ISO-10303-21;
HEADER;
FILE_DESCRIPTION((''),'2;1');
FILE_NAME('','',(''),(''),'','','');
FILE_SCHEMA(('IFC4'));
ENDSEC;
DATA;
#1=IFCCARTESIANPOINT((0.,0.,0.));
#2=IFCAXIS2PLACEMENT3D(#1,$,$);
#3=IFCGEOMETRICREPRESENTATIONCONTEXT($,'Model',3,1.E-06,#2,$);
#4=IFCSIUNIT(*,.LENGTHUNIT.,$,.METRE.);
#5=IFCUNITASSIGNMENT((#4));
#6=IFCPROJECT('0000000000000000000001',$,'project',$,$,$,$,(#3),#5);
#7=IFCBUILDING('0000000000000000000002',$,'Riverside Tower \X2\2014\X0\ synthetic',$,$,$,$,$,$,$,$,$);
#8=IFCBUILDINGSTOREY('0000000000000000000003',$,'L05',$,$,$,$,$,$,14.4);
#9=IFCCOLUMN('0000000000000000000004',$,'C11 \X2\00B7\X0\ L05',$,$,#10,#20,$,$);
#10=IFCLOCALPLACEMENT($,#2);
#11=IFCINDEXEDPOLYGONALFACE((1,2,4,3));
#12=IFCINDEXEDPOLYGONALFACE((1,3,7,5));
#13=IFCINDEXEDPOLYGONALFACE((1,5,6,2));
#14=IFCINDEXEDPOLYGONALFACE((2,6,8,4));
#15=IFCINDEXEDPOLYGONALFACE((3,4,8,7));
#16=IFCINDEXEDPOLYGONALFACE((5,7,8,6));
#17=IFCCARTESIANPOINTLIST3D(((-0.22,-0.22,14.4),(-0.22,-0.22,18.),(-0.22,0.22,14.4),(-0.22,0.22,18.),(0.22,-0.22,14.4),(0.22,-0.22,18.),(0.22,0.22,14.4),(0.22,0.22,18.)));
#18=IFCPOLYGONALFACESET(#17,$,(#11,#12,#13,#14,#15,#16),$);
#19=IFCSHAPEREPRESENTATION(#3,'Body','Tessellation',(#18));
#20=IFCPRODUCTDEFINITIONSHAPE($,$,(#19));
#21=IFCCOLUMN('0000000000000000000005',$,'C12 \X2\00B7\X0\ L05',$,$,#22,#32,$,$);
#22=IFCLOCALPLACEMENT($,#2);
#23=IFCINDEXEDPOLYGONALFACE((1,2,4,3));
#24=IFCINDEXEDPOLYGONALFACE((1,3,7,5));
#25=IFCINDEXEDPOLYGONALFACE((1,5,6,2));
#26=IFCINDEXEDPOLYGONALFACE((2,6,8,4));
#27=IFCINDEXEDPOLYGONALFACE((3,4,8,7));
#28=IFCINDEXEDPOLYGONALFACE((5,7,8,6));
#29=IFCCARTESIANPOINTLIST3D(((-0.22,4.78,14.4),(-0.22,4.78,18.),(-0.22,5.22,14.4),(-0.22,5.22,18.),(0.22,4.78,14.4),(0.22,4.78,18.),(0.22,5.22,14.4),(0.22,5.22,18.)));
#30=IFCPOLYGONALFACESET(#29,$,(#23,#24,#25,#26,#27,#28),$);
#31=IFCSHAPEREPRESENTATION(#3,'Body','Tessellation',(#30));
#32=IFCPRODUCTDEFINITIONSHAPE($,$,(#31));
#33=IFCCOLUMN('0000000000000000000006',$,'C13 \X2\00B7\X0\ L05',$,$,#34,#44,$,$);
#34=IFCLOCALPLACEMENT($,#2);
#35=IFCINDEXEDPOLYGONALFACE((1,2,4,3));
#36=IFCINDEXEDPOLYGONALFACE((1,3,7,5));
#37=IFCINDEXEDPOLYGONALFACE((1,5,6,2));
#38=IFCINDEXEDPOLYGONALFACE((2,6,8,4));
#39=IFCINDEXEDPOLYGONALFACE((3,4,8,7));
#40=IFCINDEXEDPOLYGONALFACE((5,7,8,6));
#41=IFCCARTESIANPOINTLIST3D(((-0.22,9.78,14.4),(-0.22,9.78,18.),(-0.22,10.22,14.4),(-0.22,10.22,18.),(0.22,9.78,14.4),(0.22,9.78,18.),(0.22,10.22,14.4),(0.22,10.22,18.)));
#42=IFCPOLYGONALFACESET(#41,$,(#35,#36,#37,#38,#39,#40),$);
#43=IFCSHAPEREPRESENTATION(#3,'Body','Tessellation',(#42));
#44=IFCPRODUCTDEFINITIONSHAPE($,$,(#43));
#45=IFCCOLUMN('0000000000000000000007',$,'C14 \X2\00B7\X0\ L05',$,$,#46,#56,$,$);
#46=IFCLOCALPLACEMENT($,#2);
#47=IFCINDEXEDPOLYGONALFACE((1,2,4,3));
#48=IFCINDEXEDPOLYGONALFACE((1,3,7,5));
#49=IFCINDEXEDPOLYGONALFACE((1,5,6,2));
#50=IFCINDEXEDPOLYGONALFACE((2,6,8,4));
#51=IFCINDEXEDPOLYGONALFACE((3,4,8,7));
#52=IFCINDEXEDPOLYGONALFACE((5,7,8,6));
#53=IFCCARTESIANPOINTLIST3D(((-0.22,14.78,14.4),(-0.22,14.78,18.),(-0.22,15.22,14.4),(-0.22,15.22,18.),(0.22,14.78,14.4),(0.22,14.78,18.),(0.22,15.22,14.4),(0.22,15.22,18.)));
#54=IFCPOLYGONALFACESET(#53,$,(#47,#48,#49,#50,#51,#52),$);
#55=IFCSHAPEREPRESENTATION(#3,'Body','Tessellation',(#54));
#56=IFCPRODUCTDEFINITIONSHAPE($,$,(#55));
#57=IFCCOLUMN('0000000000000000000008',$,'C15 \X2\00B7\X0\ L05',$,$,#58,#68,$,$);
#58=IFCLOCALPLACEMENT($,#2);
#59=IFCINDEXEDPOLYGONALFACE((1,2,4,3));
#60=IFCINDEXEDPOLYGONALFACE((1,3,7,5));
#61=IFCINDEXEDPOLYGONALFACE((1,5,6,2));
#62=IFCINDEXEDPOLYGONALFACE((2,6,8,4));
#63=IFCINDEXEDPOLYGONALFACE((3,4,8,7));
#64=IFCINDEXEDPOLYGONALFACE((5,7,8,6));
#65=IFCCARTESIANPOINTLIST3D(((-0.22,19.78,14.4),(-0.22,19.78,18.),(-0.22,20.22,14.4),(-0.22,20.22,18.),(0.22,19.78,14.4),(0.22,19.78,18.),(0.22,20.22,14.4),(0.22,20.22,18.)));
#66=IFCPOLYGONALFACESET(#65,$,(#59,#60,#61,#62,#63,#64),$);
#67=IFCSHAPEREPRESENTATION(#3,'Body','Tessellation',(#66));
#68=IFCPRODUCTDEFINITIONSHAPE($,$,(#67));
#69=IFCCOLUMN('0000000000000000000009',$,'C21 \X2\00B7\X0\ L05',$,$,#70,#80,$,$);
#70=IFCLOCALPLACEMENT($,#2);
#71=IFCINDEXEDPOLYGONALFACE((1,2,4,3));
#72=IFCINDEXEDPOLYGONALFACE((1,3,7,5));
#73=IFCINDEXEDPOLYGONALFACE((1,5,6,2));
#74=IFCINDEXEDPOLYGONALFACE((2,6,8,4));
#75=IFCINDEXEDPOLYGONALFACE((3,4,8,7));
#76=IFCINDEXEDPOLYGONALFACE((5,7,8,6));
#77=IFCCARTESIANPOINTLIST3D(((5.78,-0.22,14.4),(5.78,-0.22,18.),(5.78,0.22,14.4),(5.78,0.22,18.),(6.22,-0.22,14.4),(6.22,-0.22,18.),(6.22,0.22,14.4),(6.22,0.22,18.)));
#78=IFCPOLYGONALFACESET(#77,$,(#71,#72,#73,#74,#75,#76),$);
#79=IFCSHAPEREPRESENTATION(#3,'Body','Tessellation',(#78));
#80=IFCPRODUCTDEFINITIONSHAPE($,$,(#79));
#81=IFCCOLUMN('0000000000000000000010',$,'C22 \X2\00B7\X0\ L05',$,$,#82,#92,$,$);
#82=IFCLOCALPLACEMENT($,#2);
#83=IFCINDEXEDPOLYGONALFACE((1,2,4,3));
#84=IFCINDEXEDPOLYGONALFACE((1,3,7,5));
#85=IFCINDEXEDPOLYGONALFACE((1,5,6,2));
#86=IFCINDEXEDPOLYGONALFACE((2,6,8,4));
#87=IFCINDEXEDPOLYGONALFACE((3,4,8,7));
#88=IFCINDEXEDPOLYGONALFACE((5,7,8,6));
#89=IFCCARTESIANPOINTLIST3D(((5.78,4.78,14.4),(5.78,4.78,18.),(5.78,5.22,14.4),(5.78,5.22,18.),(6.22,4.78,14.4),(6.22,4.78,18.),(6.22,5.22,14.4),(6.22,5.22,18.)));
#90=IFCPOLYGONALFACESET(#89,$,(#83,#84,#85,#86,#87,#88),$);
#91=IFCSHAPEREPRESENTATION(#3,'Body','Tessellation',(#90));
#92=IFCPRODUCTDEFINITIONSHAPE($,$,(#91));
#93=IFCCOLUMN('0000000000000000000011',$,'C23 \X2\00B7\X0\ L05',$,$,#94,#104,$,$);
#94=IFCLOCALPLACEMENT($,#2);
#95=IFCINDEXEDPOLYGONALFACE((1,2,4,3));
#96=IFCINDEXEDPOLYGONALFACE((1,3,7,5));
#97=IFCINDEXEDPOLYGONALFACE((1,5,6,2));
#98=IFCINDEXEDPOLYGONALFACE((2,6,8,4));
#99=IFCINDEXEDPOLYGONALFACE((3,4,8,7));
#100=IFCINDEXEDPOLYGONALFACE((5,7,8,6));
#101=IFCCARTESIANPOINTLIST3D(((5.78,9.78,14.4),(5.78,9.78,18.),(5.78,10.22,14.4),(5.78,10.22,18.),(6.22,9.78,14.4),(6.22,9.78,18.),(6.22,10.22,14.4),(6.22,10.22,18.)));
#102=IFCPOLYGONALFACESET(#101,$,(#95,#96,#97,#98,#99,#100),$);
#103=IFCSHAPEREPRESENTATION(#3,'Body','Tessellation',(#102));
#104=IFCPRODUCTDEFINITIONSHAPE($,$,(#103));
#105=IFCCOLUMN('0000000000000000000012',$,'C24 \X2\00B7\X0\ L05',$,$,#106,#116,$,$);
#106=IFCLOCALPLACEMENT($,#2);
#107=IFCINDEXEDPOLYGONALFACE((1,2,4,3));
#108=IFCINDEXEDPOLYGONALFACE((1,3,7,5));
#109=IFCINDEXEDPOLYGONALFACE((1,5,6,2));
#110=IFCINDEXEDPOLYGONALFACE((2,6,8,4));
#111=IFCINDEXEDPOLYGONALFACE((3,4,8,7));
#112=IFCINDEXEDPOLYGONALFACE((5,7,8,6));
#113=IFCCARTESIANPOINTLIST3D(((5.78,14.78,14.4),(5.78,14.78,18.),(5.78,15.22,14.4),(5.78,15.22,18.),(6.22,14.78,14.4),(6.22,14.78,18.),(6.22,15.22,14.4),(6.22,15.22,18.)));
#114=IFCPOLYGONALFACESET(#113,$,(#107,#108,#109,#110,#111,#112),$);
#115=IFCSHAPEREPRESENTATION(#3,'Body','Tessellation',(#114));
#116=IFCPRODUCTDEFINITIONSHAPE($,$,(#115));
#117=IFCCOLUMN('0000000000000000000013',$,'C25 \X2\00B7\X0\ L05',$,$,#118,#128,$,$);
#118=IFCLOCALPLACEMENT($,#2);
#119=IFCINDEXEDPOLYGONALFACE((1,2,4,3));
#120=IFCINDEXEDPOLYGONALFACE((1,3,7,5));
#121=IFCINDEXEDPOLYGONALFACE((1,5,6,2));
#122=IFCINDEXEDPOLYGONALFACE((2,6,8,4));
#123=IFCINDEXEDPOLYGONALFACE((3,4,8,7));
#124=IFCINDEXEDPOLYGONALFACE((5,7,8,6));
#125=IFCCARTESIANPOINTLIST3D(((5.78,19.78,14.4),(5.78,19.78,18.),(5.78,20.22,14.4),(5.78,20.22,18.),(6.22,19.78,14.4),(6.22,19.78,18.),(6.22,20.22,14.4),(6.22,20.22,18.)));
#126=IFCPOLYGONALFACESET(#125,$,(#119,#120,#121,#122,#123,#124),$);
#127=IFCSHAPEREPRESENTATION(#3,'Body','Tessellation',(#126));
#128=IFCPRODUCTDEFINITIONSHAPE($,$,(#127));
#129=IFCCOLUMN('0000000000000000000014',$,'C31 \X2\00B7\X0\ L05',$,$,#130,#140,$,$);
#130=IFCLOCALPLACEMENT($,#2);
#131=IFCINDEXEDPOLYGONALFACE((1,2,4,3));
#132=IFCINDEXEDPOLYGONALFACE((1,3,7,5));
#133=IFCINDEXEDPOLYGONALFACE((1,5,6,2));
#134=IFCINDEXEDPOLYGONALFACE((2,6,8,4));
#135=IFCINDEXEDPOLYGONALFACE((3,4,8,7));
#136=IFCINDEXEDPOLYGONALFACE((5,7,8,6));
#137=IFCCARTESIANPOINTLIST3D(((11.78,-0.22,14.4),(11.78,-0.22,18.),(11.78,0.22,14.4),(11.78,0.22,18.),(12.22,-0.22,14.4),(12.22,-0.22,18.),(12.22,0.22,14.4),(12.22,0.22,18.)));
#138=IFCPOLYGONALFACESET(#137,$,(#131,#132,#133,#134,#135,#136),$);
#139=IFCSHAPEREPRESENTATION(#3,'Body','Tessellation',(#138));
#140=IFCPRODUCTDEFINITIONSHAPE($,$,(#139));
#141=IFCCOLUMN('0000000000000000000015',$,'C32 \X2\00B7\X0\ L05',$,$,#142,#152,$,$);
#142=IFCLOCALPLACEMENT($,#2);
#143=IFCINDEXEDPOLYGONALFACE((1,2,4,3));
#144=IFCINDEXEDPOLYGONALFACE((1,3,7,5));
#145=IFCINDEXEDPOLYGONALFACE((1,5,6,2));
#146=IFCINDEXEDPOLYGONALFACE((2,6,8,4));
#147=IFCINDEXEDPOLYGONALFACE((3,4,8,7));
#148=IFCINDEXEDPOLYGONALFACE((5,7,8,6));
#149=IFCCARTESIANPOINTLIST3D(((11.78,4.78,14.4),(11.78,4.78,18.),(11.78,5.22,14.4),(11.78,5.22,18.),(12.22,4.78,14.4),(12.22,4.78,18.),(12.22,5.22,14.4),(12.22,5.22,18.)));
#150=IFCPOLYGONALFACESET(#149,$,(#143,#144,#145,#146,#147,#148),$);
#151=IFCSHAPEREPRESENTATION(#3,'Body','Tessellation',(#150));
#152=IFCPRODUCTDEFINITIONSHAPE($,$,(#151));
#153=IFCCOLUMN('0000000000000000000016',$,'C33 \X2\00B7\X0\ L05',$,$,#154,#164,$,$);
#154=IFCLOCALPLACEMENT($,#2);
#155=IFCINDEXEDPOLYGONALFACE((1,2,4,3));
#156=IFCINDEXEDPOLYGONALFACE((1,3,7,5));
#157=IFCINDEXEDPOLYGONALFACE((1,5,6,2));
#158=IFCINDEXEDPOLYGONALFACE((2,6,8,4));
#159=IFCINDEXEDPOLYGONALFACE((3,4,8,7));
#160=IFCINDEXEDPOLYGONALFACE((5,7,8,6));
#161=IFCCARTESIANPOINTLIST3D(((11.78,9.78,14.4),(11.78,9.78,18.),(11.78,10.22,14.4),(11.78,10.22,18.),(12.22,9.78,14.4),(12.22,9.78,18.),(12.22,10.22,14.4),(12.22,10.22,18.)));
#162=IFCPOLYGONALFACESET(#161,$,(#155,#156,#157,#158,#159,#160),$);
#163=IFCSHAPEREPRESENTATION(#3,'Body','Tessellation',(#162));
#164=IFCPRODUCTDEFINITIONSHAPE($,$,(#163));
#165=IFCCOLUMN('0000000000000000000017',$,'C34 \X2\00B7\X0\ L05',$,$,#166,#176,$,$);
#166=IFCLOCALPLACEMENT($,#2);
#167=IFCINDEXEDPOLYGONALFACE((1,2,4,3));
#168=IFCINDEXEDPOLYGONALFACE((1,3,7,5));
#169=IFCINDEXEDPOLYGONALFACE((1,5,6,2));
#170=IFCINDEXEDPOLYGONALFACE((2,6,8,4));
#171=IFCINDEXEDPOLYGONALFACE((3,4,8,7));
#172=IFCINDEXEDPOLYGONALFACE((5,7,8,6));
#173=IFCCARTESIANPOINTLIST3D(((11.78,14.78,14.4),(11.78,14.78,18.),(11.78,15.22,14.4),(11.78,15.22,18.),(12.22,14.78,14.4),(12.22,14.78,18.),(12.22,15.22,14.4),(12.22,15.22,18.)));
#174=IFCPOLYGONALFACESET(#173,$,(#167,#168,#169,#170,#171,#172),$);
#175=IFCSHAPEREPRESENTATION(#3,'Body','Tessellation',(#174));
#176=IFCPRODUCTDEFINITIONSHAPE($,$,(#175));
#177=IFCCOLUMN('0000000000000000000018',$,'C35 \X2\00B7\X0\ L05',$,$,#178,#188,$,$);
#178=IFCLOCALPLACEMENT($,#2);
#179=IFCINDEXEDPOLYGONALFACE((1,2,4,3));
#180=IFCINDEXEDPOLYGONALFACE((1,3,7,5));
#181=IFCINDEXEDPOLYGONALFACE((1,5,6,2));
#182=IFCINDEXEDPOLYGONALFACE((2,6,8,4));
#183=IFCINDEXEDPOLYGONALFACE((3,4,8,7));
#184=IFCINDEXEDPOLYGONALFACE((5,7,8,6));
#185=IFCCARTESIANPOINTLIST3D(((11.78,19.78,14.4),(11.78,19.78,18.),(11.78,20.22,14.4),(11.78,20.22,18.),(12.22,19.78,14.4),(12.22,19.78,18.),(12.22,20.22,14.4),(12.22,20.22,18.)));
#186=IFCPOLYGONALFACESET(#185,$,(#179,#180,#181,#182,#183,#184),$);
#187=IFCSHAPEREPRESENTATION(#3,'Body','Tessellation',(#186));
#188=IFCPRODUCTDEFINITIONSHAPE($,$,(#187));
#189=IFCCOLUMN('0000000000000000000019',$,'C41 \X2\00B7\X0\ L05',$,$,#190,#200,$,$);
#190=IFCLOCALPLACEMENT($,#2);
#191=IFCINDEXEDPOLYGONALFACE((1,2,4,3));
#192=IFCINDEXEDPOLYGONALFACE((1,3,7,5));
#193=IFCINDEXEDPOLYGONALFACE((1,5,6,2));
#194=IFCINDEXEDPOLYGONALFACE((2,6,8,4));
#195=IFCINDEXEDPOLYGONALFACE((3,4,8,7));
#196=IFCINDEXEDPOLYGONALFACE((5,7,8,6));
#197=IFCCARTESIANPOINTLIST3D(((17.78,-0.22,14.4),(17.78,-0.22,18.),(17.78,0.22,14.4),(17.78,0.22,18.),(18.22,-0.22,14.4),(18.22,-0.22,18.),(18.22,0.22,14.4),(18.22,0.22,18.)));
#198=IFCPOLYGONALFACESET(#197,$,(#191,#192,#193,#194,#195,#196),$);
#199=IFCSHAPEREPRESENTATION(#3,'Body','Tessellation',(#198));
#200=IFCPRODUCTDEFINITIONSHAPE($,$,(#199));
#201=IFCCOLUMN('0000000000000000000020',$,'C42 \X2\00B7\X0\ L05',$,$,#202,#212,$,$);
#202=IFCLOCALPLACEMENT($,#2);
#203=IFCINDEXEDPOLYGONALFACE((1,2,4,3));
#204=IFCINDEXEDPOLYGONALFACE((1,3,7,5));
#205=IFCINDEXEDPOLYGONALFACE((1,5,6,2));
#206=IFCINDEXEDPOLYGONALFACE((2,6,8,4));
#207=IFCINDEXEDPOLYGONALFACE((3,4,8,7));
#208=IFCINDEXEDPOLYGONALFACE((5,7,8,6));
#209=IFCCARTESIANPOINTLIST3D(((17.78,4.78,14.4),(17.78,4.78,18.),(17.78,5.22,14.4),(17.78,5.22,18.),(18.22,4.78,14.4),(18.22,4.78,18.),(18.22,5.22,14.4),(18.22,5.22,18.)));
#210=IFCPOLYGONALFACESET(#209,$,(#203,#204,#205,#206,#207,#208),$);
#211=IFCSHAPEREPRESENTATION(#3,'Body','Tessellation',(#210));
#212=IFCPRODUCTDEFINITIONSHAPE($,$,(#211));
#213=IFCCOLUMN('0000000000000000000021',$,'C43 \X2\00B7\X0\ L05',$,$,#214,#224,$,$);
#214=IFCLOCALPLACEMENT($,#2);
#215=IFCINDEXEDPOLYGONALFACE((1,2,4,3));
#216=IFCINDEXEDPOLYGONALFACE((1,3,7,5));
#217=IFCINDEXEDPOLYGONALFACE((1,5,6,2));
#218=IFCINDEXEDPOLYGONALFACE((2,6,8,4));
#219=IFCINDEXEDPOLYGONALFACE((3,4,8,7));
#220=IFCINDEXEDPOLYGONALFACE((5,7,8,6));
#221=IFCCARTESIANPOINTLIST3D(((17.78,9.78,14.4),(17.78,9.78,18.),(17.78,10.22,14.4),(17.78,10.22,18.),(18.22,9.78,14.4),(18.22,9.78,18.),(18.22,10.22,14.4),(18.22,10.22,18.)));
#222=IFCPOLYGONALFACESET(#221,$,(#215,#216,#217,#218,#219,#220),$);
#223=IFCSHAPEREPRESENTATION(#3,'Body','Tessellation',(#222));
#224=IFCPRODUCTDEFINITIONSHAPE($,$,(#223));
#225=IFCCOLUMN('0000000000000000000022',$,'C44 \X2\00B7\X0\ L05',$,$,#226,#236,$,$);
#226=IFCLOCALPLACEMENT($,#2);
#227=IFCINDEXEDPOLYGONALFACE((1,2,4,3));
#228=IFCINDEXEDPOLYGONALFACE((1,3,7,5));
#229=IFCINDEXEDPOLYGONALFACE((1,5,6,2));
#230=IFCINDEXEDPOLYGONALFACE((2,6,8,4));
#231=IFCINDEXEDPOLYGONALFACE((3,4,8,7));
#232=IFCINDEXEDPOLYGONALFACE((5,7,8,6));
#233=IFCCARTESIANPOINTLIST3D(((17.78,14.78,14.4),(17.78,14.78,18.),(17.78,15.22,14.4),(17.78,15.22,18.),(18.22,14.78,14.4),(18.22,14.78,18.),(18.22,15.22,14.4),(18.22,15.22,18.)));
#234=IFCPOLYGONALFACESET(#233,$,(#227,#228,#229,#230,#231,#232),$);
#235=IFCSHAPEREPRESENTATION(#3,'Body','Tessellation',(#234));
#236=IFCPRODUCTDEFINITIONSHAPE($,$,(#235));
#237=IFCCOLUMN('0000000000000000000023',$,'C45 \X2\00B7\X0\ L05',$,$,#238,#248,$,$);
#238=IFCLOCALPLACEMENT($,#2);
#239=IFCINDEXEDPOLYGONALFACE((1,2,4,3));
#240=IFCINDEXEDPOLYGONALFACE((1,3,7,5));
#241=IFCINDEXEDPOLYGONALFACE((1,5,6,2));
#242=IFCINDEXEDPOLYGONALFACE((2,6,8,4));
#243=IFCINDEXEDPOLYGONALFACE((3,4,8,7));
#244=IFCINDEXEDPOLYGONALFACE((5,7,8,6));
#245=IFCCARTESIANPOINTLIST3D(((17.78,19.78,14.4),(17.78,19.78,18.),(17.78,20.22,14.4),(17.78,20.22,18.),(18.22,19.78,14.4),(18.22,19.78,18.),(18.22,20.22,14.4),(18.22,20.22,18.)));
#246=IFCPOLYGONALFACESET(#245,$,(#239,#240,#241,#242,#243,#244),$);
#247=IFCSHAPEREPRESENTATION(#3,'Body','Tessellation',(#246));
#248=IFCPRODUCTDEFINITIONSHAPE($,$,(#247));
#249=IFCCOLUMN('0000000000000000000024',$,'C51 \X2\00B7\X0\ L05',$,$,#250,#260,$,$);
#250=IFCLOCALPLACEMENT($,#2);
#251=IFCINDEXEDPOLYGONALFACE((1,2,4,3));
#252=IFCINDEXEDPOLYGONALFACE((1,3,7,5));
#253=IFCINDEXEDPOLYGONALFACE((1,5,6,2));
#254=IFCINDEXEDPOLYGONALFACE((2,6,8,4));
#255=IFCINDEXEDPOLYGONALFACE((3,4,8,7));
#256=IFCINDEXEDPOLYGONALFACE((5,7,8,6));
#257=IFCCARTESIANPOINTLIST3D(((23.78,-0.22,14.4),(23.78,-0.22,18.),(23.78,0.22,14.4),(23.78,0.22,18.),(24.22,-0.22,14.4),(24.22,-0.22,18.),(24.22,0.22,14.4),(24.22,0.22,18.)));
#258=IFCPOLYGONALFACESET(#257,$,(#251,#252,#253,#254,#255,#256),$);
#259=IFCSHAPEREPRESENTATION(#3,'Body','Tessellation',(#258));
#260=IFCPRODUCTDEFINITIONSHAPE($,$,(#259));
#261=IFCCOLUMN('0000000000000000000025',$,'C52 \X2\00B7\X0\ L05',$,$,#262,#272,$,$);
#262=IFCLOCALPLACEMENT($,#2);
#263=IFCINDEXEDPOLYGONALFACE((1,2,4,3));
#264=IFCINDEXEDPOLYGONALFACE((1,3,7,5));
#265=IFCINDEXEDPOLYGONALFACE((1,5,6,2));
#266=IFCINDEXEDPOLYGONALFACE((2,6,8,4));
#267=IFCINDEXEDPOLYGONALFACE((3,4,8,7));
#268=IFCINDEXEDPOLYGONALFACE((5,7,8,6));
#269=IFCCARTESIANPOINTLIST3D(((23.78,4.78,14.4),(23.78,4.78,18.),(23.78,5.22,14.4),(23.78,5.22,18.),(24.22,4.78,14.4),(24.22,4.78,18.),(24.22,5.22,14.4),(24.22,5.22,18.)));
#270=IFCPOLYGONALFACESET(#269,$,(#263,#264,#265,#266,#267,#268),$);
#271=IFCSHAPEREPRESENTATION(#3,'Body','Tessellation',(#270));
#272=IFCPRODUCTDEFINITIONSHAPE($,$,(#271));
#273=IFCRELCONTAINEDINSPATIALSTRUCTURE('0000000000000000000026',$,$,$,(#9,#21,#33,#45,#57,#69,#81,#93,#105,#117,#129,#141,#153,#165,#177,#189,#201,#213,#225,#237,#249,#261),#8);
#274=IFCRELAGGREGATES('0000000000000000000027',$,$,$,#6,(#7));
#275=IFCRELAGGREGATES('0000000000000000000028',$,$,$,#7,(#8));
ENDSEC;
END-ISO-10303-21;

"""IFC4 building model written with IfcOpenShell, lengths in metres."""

from ifc_helpers import new_model, si_unit, frame, origin, place, context, project, spatial, rectangle, extrude, element, save


model = new_model("IFC4")

# Units and contexts
model_context = context("Model", 3, precision=1e-06, world=origin())
ifc_project = project(units=[si_unit("LENGTHUNIT", "METRE")], contexts=[model_context])

# Building, storey
building = spatial("IfcBuilding", under=ifc_project, Name="Riverside Tower — synthetic")
storey = spatial("IfcBuildingStorey", under=building, Name="L05", Elevation=14.4)

# Columns
for number, where, name in (
    (1, (0.0, 0.0, 14.4), "C11 · L05"),
    (2, (0.0, 5.0, 14.4), "C12 · L05"),
    (3, (0.0, 10.0, 14.4), "C13 · L05"),
    (4, (0.0, 15.0, 14.4), "C14 · L05"),
    (5, (0.0, 20.0, 14.4), "C15 · L05"),
    (6, (6.0, 0.0, 14.4), "C21 · L05"),
    (7, (6.0, 5.0, 14.4), "C22 · L05"),
    (8, (6.0, 10.0, 14.4), "C23 · L05"),
    (9, (6.0, 15.0, 14.4), "C24 · L05"),
    (10, (6.0, 20.0, 14.4), "C25 · L05"),
    (11, (12.0, 0.0, 14.4), "C31 · L05"),
    (12, (12.0, 5.0, 14.4), "C32 · L05"),
    (13, (12.0, 10.0, 14.4), "C33 · L05"),
    (14, (12.0, 15.0, 14.4), "C34 · L05"),
    (15, (12.0, 20.0, 14.4), "C35 · L05"),
    (16, (18.0, 0.0, 14.4), "C41 · L05"),
    (17, (18.0, 5.0, 14.4), "C42 · L05"),
    (18, (18.0, 10.0, 14.4), "C43 · L05"),
    (19, (18.0, 15.0, 14.4), "C44 · L05"),
    (20, (18.0, 20.0, 14.4), "C45 · L05"),
    (21, (24.0, 0.0, 14.4), "C51 · L05"),
    (22, (24.0, 5.0, 14.4), "C52 · L05"),
):
    element("IfcColumn", number, at=place(None, frame(where)), inside=storey, Name=name, context=model_context, shape_type="SweptSolid", body=[
        extrude(rectangle(XDim=0.44, YDim=0.44), origin(), (0.0, 0.0, 1.0), 3.6),
    ])

save(model, "model.ifc")
